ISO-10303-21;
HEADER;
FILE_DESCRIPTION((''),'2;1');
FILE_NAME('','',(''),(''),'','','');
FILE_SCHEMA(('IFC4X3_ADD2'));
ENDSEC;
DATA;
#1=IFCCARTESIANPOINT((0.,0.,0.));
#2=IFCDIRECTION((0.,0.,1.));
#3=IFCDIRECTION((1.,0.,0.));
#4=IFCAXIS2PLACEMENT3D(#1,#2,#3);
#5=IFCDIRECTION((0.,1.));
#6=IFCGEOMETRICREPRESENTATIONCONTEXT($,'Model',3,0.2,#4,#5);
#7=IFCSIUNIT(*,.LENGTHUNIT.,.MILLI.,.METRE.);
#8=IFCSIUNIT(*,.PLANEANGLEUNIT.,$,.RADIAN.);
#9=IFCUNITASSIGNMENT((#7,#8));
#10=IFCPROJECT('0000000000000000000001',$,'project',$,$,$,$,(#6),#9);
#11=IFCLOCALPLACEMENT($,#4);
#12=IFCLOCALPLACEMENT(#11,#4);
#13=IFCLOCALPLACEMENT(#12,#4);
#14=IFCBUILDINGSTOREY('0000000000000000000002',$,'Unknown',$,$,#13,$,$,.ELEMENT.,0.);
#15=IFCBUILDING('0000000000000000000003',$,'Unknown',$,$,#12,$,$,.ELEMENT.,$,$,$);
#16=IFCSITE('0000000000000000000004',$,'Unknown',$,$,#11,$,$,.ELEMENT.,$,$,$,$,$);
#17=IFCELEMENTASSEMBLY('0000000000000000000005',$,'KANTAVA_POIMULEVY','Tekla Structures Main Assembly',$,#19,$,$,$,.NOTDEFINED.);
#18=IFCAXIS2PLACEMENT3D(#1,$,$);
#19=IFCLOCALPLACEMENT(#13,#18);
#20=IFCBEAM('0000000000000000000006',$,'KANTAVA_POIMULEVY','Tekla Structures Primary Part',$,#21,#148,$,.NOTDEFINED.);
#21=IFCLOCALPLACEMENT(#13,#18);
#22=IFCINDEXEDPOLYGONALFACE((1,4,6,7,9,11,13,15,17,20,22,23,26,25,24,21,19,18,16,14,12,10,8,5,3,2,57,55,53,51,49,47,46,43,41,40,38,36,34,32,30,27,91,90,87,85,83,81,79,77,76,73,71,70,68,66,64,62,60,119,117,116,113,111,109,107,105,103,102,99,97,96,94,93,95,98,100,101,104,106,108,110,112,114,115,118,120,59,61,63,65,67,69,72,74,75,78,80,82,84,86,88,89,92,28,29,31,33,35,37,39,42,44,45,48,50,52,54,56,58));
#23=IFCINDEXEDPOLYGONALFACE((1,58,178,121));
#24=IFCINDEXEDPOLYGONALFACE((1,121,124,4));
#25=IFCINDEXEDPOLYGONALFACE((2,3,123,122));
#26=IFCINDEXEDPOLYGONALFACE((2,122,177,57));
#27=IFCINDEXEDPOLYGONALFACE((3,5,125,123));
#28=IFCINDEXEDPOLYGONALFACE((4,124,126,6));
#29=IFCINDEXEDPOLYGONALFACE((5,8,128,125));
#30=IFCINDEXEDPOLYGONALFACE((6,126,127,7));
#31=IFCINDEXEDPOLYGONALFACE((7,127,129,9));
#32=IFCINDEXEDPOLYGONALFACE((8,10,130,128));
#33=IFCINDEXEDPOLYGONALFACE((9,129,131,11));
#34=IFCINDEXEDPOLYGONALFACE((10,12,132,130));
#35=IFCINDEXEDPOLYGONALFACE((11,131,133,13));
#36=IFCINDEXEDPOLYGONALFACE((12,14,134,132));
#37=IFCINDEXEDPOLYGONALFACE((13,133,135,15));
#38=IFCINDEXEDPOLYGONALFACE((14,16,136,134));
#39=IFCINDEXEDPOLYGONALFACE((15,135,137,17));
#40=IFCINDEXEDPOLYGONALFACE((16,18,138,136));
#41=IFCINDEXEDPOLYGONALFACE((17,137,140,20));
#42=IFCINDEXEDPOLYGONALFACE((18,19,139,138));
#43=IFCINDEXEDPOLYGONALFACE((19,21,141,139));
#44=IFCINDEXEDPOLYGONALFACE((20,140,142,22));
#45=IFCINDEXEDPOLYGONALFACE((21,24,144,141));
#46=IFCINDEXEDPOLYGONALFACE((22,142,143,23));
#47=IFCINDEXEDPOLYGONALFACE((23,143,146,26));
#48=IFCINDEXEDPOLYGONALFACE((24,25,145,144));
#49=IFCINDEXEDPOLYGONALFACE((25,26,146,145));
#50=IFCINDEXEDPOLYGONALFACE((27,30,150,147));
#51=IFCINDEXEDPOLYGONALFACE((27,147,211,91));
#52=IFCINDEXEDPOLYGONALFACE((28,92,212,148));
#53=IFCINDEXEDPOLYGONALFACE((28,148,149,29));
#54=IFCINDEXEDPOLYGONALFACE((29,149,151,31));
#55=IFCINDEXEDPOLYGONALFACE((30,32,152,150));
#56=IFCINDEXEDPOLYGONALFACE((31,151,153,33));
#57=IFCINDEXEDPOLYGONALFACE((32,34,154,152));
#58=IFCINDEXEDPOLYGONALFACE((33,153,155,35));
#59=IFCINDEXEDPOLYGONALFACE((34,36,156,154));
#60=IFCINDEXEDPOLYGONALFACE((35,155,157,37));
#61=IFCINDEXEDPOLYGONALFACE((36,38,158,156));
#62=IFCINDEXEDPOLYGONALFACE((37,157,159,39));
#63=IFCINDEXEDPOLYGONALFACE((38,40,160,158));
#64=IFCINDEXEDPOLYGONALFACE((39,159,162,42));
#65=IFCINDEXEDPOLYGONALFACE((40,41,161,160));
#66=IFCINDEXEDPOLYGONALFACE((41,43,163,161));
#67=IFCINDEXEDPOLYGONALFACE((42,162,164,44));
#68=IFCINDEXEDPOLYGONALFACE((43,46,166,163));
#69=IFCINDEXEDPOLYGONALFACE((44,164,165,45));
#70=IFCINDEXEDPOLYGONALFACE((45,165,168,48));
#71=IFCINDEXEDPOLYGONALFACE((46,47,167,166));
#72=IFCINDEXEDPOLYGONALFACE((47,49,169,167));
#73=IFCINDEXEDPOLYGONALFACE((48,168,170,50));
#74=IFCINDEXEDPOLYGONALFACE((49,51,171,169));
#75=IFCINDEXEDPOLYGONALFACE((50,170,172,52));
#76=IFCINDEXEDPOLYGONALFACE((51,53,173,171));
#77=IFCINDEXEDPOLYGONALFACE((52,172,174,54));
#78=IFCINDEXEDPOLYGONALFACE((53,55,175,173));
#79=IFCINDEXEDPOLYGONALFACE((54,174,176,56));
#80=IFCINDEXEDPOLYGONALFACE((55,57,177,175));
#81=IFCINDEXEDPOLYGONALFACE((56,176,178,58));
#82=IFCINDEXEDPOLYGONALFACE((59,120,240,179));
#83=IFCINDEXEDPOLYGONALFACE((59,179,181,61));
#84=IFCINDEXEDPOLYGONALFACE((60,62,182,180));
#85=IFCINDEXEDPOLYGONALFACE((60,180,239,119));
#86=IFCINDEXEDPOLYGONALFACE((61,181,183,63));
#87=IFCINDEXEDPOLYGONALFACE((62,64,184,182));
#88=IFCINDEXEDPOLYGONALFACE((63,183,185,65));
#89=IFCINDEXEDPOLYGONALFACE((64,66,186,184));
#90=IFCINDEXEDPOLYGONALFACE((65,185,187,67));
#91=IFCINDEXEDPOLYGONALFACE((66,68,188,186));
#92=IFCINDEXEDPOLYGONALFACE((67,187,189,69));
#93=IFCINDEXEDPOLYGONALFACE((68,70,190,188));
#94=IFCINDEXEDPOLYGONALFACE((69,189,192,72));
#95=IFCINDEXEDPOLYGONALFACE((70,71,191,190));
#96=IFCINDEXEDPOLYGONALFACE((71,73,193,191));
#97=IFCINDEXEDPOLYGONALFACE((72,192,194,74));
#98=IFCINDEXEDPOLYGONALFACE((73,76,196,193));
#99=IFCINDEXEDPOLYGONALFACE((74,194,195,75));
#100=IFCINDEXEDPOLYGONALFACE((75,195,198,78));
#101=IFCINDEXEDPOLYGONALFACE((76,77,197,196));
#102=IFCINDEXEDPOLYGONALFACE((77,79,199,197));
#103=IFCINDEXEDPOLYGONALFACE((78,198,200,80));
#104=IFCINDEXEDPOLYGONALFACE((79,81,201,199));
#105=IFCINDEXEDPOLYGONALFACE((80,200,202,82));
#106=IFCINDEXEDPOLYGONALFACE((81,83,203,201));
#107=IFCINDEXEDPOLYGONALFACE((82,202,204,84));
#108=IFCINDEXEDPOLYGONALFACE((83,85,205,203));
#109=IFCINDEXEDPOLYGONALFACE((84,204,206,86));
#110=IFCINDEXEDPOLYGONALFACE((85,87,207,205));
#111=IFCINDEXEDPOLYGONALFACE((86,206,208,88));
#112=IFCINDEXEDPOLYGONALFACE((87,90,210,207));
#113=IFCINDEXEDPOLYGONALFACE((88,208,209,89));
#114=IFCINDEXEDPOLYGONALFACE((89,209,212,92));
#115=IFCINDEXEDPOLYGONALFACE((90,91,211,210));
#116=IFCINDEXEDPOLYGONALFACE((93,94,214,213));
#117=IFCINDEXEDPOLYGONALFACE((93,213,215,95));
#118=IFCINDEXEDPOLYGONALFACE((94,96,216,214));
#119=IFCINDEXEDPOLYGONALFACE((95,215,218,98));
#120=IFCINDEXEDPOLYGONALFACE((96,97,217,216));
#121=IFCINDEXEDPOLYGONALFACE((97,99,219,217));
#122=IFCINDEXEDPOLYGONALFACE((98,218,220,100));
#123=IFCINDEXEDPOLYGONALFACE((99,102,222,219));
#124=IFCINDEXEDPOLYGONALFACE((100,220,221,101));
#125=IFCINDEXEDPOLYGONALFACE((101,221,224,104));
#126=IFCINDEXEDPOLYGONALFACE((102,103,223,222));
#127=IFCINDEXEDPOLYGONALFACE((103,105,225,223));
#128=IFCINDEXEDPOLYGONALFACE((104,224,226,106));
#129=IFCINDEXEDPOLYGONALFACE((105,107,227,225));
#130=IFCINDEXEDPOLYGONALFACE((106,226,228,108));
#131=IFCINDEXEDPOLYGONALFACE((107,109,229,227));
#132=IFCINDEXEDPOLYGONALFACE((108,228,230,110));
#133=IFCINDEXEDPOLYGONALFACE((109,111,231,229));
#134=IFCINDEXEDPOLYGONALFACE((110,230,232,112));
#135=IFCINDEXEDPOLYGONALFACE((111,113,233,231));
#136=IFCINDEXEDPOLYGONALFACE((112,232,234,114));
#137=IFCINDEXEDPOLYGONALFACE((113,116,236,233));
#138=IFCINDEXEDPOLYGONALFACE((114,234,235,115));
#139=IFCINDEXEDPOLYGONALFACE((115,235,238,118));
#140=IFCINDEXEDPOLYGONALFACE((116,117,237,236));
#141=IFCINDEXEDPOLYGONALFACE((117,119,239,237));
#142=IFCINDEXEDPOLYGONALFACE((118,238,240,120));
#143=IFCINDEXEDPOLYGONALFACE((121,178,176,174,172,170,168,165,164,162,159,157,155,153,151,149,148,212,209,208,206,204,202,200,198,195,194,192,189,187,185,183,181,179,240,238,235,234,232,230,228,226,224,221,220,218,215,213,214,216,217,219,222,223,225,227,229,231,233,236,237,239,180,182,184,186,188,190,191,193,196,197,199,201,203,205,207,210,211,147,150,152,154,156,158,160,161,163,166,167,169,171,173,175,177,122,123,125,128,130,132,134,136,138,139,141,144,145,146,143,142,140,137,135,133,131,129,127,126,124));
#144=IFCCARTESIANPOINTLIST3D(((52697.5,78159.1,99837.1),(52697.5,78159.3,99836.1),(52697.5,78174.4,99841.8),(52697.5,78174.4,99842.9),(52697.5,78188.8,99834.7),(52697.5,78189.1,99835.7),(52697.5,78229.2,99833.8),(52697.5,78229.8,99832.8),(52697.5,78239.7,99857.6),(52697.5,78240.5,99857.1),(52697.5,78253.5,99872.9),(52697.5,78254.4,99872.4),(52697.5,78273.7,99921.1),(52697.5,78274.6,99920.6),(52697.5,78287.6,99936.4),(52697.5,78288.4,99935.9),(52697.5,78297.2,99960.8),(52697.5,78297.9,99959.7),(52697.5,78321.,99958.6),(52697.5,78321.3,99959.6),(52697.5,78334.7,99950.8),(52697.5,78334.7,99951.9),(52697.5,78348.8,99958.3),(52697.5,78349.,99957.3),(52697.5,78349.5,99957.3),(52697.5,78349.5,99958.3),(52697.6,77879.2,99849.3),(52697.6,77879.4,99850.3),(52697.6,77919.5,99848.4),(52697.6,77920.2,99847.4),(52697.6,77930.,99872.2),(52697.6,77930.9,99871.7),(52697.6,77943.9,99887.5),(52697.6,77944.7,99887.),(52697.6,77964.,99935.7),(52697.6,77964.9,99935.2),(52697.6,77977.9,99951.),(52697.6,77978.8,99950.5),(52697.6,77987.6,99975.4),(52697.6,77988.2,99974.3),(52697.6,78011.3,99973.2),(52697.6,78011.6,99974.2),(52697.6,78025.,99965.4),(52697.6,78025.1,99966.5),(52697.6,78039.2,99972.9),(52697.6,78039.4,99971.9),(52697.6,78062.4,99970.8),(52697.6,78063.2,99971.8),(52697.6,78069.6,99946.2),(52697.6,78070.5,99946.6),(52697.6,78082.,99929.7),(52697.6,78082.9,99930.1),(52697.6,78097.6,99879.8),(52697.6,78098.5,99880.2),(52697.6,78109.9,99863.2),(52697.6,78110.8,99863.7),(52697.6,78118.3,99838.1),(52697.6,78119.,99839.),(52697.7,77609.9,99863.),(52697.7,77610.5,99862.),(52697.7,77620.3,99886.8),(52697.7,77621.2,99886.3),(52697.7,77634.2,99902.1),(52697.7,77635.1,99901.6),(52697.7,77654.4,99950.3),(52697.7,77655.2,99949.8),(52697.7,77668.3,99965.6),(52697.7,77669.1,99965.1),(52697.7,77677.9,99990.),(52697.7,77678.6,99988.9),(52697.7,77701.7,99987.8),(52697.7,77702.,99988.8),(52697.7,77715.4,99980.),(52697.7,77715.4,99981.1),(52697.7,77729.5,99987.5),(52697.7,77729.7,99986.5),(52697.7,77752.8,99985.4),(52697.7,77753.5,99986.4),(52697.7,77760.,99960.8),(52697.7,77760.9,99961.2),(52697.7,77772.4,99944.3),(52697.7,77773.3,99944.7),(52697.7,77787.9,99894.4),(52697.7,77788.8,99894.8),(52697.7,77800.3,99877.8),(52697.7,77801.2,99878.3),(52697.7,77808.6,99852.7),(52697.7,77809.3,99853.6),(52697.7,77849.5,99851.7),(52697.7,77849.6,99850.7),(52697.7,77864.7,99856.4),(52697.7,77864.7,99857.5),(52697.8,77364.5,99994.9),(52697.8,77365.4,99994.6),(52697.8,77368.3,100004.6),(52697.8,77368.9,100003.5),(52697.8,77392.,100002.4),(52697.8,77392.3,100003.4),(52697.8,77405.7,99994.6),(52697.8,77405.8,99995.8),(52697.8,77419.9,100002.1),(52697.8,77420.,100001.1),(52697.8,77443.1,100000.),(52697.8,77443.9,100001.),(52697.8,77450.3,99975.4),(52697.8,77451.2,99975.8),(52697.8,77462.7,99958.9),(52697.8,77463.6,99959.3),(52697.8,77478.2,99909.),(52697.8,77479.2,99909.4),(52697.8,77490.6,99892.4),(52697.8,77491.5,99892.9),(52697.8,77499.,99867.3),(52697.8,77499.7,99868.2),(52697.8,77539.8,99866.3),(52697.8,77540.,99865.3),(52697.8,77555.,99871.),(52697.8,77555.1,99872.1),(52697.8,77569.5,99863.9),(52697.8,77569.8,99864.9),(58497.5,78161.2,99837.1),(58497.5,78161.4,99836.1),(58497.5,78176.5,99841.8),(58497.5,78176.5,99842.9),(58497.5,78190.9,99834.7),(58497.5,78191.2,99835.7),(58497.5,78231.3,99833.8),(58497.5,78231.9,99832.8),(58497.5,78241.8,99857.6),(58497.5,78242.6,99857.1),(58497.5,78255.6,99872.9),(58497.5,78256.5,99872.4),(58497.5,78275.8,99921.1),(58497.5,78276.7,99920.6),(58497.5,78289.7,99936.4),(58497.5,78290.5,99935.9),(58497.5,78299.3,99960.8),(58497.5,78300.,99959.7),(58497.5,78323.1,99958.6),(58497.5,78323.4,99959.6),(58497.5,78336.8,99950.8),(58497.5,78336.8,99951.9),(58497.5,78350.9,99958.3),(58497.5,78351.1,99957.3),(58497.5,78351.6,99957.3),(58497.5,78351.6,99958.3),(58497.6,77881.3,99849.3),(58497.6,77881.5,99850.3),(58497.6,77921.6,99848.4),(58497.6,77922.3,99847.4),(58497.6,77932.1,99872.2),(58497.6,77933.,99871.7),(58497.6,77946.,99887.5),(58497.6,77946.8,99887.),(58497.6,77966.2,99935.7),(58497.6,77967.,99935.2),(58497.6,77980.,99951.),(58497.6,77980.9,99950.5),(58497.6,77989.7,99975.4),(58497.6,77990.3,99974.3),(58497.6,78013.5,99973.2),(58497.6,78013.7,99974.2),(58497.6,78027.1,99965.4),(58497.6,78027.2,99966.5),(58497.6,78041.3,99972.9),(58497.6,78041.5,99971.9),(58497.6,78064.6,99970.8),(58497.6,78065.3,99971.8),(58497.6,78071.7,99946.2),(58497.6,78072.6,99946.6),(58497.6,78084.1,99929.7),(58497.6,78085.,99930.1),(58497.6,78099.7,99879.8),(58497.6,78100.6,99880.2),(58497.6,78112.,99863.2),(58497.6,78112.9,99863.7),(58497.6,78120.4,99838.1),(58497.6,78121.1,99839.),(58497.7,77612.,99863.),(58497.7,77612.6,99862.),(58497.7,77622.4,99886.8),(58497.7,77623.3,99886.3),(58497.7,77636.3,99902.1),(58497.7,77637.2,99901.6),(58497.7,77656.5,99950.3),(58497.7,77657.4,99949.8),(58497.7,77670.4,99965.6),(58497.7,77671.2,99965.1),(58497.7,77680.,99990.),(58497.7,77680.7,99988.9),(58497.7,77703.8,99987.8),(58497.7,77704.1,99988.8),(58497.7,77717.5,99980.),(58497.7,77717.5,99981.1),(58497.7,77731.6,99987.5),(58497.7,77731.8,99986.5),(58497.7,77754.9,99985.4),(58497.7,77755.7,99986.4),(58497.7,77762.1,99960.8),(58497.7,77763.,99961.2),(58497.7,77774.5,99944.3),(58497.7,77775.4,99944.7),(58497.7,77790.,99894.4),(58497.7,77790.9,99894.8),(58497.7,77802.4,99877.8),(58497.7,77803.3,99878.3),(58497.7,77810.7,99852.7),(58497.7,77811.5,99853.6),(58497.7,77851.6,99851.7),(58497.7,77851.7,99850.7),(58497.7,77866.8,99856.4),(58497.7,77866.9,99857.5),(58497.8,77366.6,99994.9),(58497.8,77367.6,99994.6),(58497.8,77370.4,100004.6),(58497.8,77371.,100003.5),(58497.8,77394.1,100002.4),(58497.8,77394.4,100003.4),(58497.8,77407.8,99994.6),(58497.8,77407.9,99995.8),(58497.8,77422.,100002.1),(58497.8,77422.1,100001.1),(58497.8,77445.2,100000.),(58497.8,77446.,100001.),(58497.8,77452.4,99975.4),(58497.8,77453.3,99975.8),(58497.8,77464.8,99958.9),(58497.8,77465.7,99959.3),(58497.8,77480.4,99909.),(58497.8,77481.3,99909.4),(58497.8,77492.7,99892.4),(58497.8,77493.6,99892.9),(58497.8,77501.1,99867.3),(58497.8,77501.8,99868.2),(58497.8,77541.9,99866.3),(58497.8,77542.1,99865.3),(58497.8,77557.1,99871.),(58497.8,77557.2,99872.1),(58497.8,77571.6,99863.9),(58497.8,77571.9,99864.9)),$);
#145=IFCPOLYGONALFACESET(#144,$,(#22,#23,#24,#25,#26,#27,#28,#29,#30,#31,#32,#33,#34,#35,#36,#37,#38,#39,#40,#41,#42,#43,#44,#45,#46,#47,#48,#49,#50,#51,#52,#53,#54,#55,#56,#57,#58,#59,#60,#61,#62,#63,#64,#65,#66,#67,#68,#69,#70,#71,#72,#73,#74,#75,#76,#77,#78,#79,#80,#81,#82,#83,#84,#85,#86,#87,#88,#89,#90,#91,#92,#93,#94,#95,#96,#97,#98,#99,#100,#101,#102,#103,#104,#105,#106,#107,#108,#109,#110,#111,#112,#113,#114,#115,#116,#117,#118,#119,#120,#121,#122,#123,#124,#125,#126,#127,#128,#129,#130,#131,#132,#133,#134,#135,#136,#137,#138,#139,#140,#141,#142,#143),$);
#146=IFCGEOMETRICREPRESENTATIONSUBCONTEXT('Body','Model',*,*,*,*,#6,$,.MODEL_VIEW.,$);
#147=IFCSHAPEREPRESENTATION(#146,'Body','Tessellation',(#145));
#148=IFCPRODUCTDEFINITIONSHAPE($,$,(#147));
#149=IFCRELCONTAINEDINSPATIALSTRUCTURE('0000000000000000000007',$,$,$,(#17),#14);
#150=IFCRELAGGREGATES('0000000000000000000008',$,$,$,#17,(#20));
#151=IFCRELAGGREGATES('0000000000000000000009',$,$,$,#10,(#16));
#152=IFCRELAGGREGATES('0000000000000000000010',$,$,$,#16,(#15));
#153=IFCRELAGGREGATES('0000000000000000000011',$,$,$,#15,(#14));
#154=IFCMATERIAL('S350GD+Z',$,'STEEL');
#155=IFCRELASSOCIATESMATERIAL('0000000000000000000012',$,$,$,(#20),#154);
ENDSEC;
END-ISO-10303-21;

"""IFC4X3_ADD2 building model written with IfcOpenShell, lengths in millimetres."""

from ifc_helpers import new_model, si_unit, direction, frame, origin_with_axes, place, context, subcontext, project, spatial, line, indexed_curve, outline, extrude, material, element, aggregate, save


model = new_model("IFC4X3_ADD2")

# Units and contexts
model_context = context("Model", 3, precision=0.2, world=origin_with_axes(), true_north=direction((0.0, 1.0)))
body_context = subcontext(model_context, "Body", "Model", "MODEL_VIEW")
ifc_project = project(units=[si_unit("LENGTHUNIT", "METRE", prefix="MILLI"), si_unit("PLANEANGLEUNIT", "RADIAN")], contexts=[model_context])

# Site, building, storey
site_placement = place(None, origin_with_axes())
site = spatial("IfcSite", under=ifc_project, at=site_placement, Name="Unknown", CompositionType="ELEMENT")
building_placement = place(site_placement, origin_with_axes())
building = spatial("IfcBuilding", under=site, at=building_placement, Name="Unknown", CompositionType="ELEMENT")
storey_placement = place(building_placement, origin_with_axes())
storey = spatial("IfcBuildingStorey", under=building, at=storey_placement, Name="Unknown", CompositionType="ELEMENT", Elevation=0.0)

# Element assembly, beam
ifc_material_1 = material(Name="S350GD+Z", Category="STEEL")
assembly_1_placement = place(storey_placement, frame((58497.7, 77869.6, 99915.5), z_axis=(-0.000363, 0.99889, -0.047106), x_axis=(-1.0, -0.000363, 0.0)))
assembly_1 = element("IfcElementAssembly", 1, at=assembly_1_placement, inside=storey, Name="KANTAVA_POIMULEVY", Description="Tekla Structures Main Assembly", PredefinedType="NOTDEFINED")
beam_1_placement = place(assembly_1_placement, origin_with_axes())
beam_1 = element("IfcBeam", 2, at=beam_1_placement, material=ifc_material_1, Name="KANTAVA_POIMULEVY", Description="Tekla Structures Primary Part", PredefinedType="NOTDEFINED", context=body_context, shape_type="SolidModel", body=[
    extrude(outline(indexed_curve([(479.5, 65.5), (478.8, 65.5), (465.0, 58.5), (451.2, 65.5), (427.1, 65.5), (418.6, 40.7), (405.5, 24.8), (387.6, -24.3), (374.5, -40.2), (365.1, -64.5), (325.0, -64.5), (310.0, -58.1), (295.0, -64.5), (254.8, -64.5), (245.5, -40.2), (232.4, -24.3), (214.5, 24.8), (201.4, 40.7), (192.9, 65.5), (168.8, 65.5), (155.0, 58.5), (141.2, 65.5), (117.1, 65.5), (108.6, 40.7), (95.5, 24.8), (77.6, -24.3), (64.5, -40.2), (55.1, -64.5), (15.0, -64.5), (0.0, -58.1), (-15.0, -64.5), (-55.2, -64.5), (-64.5, -40.2), (-77.6, -24.3), (-95.5, 24.8), (-108.6, 40.7), (-117.2, 65.5), (-141.2, 65.5), (-155.0, 58.5), (-168.8, 65.5), (-192.9, 65.5), (-201.4, 40.7), (-214.5, 24.8), (-232.4, -24.3), (-245.5, -40.2), (-254.9, -64.5), (-295.0, -64.5), (-310.0, -58.1), (-325.0, -64.5), (-365.2, -64.5), (-374.5, -40.2), (-387.6, -24.3), (-405.5, 24.8), (-418.6, 40.7), (-427.1, 65.5), (-451.2, 65.5), (-465.0, 58.5), (-478.8, 65.5), (-502.9, 65.5), (-506.2, 55.7), (-505.2, 55.4), (-502.1, 64.5), (-479.0, 64.5), (-465.0, 57.3), (-451.0, 64.5), (-427.9, 64.5), (-419.5, 40.2), (-406.4, 24.3), (-388.5, -24.8), (-375.4, -40.7), (-365.9, -65.5), (-324.8, -65.5), (-310.0, -59.1), (-295.2, -65.5), (-254.2, -65.5), (-244.6, -40.7), (-231.5, -24.8), (-213.6, 24.3), (-200.5, 40.2), (-192.1, 64.5), (-169.0, 64.5), (-155.0, 57.3), (-141.0, 64.5), (-117.9, 64.5), (-109.5, 40.2), (-96.4, 24.3), (-78.5, -24.8), (-65.4, -40.7), (-55.9, -65.5), (-14.8, -65.5), (0.0, -59.1), (14.8, -65.5), (55.8, -65.5), (65.4, -40.7), (78.5, -24.8), (96.4, 24.3), (109.5, 40.2), (117.8, 64.5), (141.0, 64.5), (155.0, 57.3), (169.0, 64.5), (192.1, 64.5), (200.5, 40.2), (213.6, 24.3), (231.5, -24.8), (244.6, -40.7), (254.1, -65.5), (295.2, -65.5), (310.0, -59.1), (324.8, -65.5), (365.8, -65.5), (375.4, -40.7), (388.5, -24.8), (406.4, 24.3), (419.5, 40.2), (427.9, 64.5), (451.0, 64.5), (465.0, 57.3), (479.0, 64.5), (479.5, 64.5)], segments=[line(1, 2, 3, 4, 5, 6, 7, 8, 9, 10, 11, 12, 13, 14, 15, 16, 17, 18, 19, 20, 21, 22, 23, 24, 25, 26, 27, 28, 29, 30, 31, 32, 33, 34, 35, 36, 37, 38, 39, 40, 41, 42, 43, 44, 45, 46, 47, 48, 49, 50, 51, 52, 53, 54, 55, 56, 57, 58, 59, 60, 61, 62, 63, 64, 65, 66, 67, 68, 69, 70, 71, 72, 73, 74, 75, 76, 77, 78, 79, 80, 81, 82, 83, 84, 85, 86, 87, 88, 89, 90, 91, 92, 93, 94, 95, 96, 97, 98, 99, 100, 101, 102, 103, 104, 105, 106, 107, 108, 109, 110, 111, 112, 113, 114, 115, 116, 117, 118, 119, 120, 1)])), frame((0.0, 0.0, 0.0), z_axis=(-1.0, 0.0, 0.0), x_axis=(0.0, 0.0, 1.0)), (0.0, 0.0, -1.0), 5800.0),
])
aggregate(assembly_1, [beam_1])

save(model, "model.ifc")
